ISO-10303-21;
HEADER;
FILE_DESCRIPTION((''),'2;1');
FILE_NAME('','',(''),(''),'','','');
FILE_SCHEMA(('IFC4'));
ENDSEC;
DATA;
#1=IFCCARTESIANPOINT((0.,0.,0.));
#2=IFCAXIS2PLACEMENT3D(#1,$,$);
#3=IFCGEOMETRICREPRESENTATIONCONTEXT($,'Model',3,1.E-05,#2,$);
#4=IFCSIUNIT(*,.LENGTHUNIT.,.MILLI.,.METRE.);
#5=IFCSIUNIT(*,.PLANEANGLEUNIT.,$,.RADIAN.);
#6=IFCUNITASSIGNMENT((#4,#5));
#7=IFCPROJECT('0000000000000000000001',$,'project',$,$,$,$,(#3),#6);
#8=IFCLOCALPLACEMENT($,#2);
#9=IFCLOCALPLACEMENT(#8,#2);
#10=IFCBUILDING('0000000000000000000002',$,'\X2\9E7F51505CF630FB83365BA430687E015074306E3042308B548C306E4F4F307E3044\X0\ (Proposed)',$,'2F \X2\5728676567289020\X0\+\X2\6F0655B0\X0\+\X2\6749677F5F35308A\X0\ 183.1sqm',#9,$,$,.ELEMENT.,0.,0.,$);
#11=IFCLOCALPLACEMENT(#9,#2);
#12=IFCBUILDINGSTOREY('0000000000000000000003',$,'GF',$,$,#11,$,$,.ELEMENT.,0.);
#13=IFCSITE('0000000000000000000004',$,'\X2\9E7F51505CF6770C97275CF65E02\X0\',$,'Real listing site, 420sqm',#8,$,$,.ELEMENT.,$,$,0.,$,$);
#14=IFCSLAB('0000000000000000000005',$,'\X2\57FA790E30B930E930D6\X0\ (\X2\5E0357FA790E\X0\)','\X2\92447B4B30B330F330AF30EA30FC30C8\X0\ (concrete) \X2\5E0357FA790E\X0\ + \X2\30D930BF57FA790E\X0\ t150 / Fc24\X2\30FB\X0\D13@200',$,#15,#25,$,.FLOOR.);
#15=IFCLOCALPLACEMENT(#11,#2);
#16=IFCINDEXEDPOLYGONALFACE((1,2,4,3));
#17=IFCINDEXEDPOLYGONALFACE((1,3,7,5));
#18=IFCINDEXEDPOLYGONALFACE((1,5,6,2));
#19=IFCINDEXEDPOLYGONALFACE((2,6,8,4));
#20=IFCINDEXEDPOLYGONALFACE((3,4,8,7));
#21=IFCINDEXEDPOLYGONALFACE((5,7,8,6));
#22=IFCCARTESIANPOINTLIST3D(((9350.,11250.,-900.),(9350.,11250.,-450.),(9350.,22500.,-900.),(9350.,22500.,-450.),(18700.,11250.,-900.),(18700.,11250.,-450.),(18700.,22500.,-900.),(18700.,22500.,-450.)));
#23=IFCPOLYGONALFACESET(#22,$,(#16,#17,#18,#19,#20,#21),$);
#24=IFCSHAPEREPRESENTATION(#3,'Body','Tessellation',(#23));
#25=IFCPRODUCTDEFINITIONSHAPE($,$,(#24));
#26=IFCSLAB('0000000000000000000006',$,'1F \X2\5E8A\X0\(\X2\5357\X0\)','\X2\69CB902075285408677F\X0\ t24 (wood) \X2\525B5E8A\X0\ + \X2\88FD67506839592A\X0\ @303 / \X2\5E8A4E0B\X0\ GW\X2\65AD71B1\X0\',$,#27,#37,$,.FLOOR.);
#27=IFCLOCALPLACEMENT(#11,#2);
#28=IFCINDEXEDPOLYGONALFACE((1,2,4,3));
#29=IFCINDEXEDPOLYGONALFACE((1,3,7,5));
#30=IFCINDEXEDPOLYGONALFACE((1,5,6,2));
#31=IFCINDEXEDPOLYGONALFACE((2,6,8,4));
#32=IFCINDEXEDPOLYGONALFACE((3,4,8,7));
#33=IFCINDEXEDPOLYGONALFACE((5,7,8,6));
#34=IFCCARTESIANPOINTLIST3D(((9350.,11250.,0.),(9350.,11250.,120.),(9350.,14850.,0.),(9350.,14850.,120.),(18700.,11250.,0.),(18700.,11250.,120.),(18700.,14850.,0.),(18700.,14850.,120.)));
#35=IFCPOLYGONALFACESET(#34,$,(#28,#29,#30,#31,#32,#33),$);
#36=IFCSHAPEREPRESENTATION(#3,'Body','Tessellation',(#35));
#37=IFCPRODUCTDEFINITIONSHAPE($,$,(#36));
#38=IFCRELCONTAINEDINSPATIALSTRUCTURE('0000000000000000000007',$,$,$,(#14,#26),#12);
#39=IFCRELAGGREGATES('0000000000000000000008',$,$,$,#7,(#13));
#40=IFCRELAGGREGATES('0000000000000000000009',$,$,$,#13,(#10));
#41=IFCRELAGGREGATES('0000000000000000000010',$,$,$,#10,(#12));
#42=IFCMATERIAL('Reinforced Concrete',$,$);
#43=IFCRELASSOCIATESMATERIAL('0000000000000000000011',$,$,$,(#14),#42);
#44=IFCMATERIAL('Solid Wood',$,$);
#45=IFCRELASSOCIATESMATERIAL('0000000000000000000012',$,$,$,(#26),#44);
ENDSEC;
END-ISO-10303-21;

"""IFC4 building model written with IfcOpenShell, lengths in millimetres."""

from ifc_helpers import new_model, si_unit, frame, frame_2d, origin, place, context, project, spatial, rectangle, extrude, material, element, save


model = new_model("IFC4")

# Units and contexts
model_context = context("Model", 3, precision=1e-05, world=origin())
ifc_project = project(units=[si_unit("LENGTHUNIT", "METRE", prefix="MILLI"), si_unit("PLANEANGLEUNIT", "RADIAN")], contexts=[model_context])

# Site, building, storey
site_placement = place(None, origin())
site = spatial("IfcSite", under=ifc_project, at=site_placement, Name="鹿児島県霧島市", ObjectType="Real listing site, 420sqm", CompositionType="ELEMENT", RefElevation=0.0)
building_placement = place(site_placement, origin())
building = spatial("IfcBuilding", under=site, at=building_placement, Name="鹿児島・茶室と縁側のある和の住まい (Proposed)", ObjectType="2F 在来木造+漆喰+杉板張り 183.1sqm", CompositionType="ELEMENT", ElevationOfRefHeight=0.0, ElevationOfTerrain=0.0)
storey_placement = place(building_placement, origin())
storey = spatial("IfcBuildingStorey", under=building, at=storey_placement, Name="GF", CompositionType="ELEMENT", Elevation=0.0)

# Shared definitions
ifc_material_1 = material(Name="Solid Wood")

# Slabs
ifc_material_2 = material(Name="Reinforced Concrete")
slab_1_placement = place(storey_placement, frame((4675.0, 5625.0, -450.0)))
element("IfcSlab", 1, at=slab_1_placement, inside=storey, material=ifc_material_2, Name="基礎スラブ (布基礎)", Description="鉄筋コンクリート (concrete) 布基礎 + ベタ基礎 t150 / Fc24・D13@200", PredefinedType="FLOOR", context=model_context, shape_type="SweptSolid", body=[
    extrude(rectangle(XDim=9350.0, YDim=11250.0, at=frame_2d((4675.0, 5625.0))), frame((4675.0, 5625.0, -450.0)), (0.0, 0.0, 1.0), 450.0),
])
slab_2_placement = place(storey_placement, frame((4675.0, 5625.0, 0.0)))
element("IfcSlab", 2, at=slab_2_placement, inside=storey, material=ifc_material_1, Name="1F 床(南)", Description="構造用合板 t24 (wood) 剛床 + 製材根太 @303 / 床下 GW断熱", PredefinedType="FLOOR", context=model_context, shape_type="SweptSolid", body=[
    extrude(rectangle(XDim=9350.0, YDim=3600.0, at=frame_2d((4675.0, 1800.0))), frame((4675.0, 5625.0, 0.0)), (0.0, 0.0, 1.0), 120.0),
])

save(model, "model.ifc")
